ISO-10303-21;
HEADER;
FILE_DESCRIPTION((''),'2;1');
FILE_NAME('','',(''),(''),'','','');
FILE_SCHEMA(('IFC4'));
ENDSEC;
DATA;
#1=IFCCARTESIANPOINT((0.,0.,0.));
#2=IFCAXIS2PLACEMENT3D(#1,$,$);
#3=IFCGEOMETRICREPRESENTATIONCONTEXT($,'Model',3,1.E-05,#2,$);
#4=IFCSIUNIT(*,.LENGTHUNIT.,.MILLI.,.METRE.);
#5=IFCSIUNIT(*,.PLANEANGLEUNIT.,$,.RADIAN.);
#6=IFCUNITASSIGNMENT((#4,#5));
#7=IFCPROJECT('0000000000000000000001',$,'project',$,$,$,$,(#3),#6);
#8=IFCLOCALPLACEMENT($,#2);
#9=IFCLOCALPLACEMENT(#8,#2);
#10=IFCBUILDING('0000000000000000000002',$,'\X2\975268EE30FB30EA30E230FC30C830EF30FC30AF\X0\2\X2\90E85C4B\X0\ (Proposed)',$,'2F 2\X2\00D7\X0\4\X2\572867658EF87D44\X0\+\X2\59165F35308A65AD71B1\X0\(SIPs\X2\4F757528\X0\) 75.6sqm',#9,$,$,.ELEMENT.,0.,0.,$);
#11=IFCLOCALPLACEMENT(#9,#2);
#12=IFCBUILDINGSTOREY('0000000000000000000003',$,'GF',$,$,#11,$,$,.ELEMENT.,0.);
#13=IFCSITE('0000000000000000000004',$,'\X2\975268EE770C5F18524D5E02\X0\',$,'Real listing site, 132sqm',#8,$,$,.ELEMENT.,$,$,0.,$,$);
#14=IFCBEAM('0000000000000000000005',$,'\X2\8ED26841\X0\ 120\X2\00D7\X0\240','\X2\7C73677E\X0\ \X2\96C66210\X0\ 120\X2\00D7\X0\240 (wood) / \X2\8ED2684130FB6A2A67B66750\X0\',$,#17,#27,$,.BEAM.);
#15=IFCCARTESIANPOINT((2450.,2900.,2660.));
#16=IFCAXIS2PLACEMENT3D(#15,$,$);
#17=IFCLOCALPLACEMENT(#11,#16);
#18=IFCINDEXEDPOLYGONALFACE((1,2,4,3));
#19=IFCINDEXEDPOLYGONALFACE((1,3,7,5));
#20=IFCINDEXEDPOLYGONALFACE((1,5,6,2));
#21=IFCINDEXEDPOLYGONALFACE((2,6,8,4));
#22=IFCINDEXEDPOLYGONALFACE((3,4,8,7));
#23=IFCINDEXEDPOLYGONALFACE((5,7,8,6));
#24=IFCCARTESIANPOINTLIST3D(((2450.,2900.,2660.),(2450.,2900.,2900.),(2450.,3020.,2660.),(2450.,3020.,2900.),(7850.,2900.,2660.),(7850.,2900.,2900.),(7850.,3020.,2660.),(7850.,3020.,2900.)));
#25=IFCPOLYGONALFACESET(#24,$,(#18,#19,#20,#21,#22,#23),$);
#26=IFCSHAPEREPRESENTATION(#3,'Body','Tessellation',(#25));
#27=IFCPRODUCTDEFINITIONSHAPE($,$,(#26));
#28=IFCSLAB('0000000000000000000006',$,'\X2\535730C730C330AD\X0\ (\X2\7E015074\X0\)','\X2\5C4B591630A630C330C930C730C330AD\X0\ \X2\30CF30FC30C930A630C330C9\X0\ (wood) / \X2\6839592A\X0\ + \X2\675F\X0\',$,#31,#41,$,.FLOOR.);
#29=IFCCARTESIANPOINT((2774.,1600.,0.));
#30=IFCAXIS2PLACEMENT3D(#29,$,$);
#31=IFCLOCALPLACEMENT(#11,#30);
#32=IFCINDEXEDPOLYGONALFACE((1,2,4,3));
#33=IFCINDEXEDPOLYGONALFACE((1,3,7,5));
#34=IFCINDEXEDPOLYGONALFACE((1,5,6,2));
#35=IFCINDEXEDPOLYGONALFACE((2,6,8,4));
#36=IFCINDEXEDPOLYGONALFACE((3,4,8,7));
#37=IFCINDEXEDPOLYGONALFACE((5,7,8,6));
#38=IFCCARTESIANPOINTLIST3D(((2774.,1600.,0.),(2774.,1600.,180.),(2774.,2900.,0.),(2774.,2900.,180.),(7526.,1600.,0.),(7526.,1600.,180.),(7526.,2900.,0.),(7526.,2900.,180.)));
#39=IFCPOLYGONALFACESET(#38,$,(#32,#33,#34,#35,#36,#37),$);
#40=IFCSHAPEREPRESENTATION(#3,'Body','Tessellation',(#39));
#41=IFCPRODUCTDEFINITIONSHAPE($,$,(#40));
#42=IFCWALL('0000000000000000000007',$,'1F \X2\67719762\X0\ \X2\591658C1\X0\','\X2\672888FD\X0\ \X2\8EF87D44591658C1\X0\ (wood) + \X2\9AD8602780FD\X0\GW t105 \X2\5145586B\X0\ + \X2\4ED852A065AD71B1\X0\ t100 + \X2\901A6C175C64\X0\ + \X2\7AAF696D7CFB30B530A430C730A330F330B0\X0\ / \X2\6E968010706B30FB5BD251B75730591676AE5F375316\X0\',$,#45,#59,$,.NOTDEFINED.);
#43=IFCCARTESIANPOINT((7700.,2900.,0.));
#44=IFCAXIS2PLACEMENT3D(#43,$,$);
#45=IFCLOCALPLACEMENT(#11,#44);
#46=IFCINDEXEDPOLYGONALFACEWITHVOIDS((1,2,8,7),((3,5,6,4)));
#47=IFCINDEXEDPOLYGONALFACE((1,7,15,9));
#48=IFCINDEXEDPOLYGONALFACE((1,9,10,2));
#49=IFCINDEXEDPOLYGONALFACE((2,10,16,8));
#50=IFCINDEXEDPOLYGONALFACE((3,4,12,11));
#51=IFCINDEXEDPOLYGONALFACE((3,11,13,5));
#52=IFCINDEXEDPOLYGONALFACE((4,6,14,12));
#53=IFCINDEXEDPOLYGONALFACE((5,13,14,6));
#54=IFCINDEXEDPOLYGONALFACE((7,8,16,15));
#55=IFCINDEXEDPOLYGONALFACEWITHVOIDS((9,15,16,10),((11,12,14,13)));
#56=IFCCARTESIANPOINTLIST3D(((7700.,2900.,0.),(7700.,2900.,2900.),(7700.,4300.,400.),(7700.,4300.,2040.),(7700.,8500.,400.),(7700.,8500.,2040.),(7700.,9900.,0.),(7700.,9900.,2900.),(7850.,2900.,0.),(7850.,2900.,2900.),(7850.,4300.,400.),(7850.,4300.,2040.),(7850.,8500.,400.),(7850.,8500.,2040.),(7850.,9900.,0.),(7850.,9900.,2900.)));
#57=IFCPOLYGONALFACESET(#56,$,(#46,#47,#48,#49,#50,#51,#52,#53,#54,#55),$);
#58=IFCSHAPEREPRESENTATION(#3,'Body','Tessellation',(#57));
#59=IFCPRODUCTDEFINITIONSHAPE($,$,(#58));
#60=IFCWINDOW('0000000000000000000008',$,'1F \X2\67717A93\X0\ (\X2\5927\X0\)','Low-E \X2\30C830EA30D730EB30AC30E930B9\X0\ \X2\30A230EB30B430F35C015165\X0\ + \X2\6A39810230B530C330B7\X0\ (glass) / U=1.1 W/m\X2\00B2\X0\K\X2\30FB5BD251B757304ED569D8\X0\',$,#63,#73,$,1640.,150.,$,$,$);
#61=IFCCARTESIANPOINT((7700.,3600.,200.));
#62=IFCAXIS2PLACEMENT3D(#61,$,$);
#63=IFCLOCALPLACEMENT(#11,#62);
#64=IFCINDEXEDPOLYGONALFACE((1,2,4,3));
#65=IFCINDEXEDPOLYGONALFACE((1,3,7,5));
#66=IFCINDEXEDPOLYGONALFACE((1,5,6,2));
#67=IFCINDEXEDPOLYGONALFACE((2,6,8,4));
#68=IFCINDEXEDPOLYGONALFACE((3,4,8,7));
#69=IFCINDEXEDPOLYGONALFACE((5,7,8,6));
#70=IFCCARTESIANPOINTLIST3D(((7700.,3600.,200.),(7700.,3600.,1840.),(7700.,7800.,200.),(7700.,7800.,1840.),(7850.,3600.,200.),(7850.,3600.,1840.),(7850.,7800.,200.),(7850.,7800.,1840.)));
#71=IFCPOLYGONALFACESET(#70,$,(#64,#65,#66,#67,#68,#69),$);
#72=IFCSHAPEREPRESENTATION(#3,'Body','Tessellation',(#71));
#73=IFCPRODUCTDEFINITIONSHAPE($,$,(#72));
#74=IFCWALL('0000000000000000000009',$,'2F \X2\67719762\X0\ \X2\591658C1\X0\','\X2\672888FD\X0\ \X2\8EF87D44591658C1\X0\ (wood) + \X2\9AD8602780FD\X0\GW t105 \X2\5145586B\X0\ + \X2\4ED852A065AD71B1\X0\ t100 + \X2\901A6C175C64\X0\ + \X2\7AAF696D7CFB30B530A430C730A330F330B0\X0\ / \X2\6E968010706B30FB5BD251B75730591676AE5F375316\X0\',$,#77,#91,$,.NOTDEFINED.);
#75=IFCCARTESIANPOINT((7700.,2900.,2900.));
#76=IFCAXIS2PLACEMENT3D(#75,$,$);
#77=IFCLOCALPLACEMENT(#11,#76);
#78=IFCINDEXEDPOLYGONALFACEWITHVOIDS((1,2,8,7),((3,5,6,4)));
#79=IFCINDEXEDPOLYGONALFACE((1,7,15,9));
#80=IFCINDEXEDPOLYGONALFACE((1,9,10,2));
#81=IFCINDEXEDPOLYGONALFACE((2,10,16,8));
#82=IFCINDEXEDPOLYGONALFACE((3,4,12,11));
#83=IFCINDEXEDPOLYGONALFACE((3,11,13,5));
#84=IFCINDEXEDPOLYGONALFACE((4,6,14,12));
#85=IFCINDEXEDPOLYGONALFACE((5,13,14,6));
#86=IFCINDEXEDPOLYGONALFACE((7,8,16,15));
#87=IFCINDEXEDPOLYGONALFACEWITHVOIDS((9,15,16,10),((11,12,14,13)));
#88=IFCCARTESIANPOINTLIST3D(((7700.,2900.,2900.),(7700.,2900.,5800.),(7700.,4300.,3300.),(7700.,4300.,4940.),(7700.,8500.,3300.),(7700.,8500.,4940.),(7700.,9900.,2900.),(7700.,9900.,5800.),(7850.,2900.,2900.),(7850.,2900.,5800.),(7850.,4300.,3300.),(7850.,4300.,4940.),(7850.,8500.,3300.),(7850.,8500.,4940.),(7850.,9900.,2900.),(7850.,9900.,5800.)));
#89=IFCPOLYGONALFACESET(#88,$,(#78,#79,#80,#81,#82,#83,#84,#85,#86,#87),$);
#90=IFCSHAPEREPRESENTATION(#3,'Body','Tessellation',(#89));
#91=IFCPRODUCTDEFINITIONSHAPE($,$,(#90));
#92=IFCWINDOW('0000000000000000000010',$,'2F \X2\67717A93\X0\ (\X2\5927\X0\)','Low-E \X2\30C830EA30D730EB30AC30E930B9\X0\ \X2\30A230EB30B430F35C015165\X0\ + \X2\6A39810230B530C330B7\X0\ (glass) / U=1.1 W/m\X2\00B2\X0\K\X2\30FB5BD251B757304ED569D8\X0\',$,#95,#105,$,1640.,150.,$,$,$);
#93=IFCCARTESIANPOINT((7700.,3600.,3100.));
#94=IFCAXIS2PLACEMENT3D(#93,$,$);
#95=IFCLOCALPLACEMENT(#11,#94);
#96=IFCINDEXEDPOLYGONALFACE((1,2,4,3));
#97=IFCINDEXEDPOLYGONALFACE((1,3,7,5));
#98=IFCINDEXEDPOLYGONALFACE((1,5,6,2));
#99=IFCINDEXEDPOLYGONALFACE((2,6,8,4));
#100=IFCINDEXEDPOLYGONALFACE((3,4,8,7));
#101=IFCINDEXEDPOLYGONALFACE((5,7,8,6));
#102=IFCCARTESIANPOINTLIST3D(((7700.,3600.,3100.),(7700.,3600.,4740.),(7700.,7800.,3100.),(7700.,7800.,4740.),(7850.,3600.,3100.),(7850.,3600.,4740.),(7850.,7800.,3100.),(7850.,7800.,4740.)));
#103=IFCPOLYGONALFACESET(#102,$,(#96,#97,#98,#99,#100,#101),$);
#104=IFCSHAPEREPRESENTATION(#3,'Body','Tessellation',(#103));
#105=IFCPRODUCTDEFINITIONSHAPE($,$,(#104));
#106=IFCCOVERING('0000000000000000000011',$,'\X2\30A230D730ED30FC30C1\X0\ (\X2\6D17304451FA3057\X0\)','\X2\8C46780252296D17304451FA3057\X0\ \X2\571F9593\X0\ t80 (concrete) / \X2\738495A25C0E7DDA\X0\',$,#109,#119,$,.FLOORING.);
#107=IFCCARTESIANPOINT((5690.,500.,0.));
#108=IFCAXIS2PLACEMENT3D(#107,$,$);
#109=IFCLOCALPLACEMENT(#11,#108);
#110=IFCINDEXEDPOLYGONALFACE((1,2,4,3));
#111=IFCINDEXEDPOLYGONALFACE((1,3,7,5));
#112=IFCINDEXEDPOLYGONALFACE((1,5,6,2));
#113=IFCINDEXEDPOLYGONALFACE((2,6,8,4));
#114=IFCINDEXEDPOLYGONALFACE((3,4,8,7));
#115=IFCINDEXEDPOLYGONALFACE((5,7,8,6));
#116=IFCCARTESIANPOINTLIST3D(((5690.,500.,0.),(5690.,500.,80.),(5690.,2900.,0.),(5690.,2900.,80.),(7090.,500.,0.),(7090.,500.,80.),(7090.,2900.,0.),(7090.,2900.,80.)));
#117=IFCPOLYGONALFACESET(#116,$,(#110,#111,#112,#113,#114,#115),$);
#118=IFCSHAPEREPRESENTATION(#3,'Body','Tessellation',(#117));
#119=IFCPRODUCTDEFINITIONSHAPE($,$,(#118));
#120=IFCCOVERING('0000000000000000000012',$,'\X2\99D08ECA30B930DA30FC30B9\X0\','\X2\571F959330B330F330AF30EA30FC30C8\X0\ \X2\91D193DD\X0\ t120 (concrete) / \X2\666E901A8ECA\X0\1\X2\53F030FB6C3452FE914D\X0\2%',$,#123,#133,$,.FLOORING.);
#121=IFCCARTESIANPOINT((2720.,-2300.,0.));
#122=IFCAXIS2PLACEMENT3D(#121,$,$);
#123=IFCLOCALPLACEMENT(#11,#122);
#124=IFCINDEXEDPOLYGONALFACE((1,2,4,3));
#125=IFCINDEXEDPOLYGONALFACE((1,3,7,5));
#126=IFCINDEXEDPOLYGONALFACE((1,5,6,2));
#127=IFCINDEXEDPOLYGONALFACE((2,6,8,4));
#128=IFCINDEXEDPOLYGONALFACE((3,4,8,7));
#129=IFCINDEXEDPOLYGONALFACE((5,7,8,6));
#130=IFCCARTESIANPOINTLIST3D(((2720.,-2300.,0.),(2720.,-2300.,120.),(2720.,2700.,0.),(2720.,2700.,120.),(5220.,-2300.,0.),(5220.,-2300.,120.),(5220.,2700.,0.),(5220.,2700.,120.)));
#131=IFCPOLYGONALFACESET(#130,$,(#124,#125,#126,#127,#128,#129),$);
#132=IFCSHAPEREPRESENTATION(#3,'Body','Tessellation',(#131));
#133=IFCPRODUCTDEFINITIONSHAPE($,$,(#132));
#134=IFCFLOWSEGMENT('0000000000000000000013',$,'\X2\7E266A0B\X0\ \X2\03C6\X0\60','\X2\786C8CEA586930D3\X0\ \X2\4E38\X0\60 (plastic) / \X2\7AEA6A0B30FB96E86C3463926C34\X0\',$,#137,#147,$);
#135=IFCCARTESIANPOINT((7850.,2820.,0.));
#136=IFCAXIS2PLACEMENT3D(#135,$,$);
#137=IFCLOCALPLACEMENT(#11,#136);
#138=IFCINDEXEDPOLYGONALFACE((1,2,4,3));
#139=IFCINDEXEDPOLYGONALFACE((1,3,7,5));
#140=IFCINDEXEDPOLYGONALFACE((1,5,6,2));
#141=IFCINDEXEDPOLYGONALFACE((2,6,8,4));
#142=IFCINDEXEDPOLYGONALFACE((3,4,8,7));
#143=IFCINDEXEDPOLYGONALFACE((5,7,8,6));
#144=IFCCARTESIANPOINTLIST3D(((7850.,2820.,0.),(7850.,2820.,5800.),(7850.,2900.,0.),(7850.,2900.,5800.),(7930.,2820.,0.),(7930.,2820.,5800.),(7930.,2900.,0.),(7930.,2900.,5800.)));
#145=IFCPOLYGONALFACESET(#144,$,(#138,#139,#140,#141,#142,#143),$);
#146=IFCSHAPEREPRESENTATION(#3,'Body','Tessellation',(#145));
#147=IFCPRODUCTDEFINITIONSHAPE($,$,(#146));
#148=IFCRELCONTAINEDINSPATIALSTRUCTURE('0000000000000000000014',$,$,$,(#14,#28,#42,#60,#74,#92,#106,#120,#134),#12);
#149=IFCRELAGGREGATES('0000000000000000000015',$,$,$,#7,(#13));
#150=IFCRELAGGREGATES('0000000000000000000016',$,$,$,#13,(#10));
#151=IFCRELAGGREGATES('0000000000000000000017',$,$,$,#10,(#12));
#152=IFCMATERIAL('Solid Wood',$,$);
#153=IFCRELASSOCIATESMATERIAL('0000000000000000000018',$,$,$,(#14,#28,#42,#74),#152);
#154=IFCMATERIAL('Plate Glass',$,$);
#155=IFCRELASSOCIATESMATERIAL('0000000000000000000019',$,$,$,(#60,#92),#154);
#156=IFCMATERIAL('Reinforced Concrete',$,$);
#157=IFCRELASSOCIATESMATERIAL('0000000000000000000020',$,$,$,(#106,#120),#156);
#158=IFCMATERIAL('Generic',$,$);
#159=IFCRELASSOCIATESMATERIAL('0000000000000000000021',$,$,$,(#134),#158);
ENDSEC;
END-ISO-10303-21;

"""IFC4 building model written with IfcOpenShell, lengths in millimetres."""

from ifc_helpers import new_model, si_unit, frame, frame_2d, origin, place, context, project, spatial, rectangle, extrude, material, element, fill, save


model = new_model("IFC4")

# Units and contexts
model_context = context("Model", 3, precision=1e-05, world=origin())
ifc_project = project(units=[si_unit("LENGTHUNIT", "METRE", prefix="MILLI"), si_unit("PLANEANGLEUNIT", "RADIAN")], contexts=[model_context])

# Site, building, storey
site_placement = place(None, origin())
site = spatial("IfcSite", under=ifc_project, at=site_placement, Name="青森県弘前市", ObjectType="Real listing site, 132sqm", CompositionType="ELEMENT", RefElevation=0.0)
building_placement = place(site_placement, origin())
building = spatial("IfcBuilding", under=site, at=building_placement, Name="青森・リモートワーク2部屋 (Proposed)", ObjectType="2F 2×4在来軸組+外張り断熱(SIPs併用) 75.6sqm", CompositionType="ELEMENT", ElevationOfRefHeight=0.0, ElevationOfTerrain=0.0)
storey_placement = place(building_placement, origin())
storey = spatial("IfcBuildingStorey", under=building, at=storey_placement, Name="GF", CompositionType="ELEMENT", Elevation=0.0)

# Shared definitions
ifc_material_1 = material(Name="Solid Wood")

# Beam
beam_1_placement = place(storey_placement, frame((2450.0, 2900.0, 2660.0)))
element("IfcBeam", 1, at=beam_1_placement, inside=storey, material=ifc_material_1, Name="軒桁 120×240", Description="米松 集成 120×240 (wood) / 軒桁・横架材", PredefinedType="BEAM", context=model_context, shape_type="SweptSolid", body=[
    extrude(rectangle(XDim=5400.0, YDim=120.0, at=frame_2d((2700.0, 60.0))), frame((2450.0, 2900.0, 2660.0)), (0.0, 0.0, 1.0), 240.0),
])

# Slab
slab_placement = place(storey_placement, frame((2774.0, 1600.0, 0.0)))
element("IfcSlab", 2, at=slab_placement, inside=storey, material=ifc_material_1, Name="南デッキ (縁側)", Description="屋外ウッドデッキ ハードウッド (wood) / 根太 + 束", PredefinedType="FLOOR", context=model_context, shape_type="SweptSolid", body=[
    extrude(rectangle(XDim=4752.0, YDim=1300.0, at=frame_2d((2376.0, 650.0))), frame((2774.0, 1600.0, 0.0)), (0.0, 0.0, 1.0), 180.0),
])

# Walls, openings, windows
wall_1_placement = place(storey_placement, frame((7700.0, 2900.0, 0.0)))
wall_1 = element("IfcWall", 3, at=wall_1_placement, inside=storey, material=ifc_material_1, Name="1F 東面 外壁", Description="木製 軸組外壁 (wood) + 高性能GW t105 充填 + 付加断熱 t100 + 通気層 + 窯業系サイディング / 準耐火・寒冷地外皮強化", PredefinedType="NOTDEFINED", context=model_context, shape_type="SweptSolid", body=[
    extrude(rectangle(XDim=150.0, YDim=7000.0, at=frame_2d((75.0, 3500.0))), frame((7700.0, 2900.0, 0.0)), (0.0, 0.0, 1.0), 2900.0),
])
opening_1_placement = place(storey_placement, frame((7700.0, 3600.0, 200.0)))
opening_1 = element("IfcOpeningElement", 4, at=opening_1_placement, cuts=wall_1, PredefinedType="NOTDEFINED", context=model_context, shape_type="SweptSolid", body=[
    extrude(rectangle(XDim=150.0, YDim=4200.0, at=frame_2d((75.0, 2100.0))), frame((7700.0, 3600.0, 200.0)), (0.0, 0.0, 1.0), 1640.0),
])
ifc_material_2 = material(Name="Plate Glass")
window_1_placement = place(storey_placement, frame((7700.0, 3600.0, 200.0)))
window_1 = element("IfcWindow", 5, at=window_1_placement, inside=storey, material=ifc_material_2, Name="1F 東窓 (大)", Description="Low-E トリプルガラス アルゴン封入 + 樹脂サッシ (glass) / U=1.1 W/m²K・寒冷地仕様", OverallHeight=1640.0, OverallWidth=150.0, context=model_context, shape_type="SweptSolid", body=[
    extrude(rectangle(XDim=150.0, YDim=4200.0, at=frame_2d((75.0, 2100.0))), frame((7700.0, 3600.0, 200.0)), (0.0, 0.0, 1.0), 1640.0),
])
fill(opening_1, window_1)
wall_2_placement = place(storey_placement, frame((7700.0, 2900.0, 2900.0)))
wall_2 = element("IfcWall", 6, at=wall_2_placement, inside=storey, material=ifc_material_1, Name="2F 東面 外壁", Description="木製 軸組外壁 (wood) + 高性能GW t105 充填 + 付加断熱 t100 + 通気層 + 窯業系サイディング / 準耐火・寒冷地外皮強化", PredefinedType="NOTDEFINED", context=model_context, shape_type="SweptSolid", body=[
    extrude(rectangle(XDim=150.0, YDim=7000.0, at=frame_2d((75.0, 3500.0))), frame((7700.0, 2900.0, 2900.0)), (0.0, 0.0, 1.0), 2900.0),
])
opening_2_placement = place(storey_placement, frame((7700.0, 3600.0, 3100.0)))
opening_2 = element("IfcOpeningElement", 7, at=opening_2_placement, cuts=wall_2, PredefinedType="NOTDEFINED", context=model_context, shape_type="SweptSolid", body=[
    extrude(rectangle(XDim=150.0, YDim=4200.0, at=frame_2d((75.0, 2100.0))), frame((7700.0, 3600.0, 3100.0)), (0.0, 0.0, 1.0), 1640.0),
])
window_2_placement = place(storey_placement, frame((7700.0, 3600.0, 3100.0)))
window_2 = element("IfcWindow", 8, at=window_2_placement, inside=storey, material=ifc_material_2, Name="2F 東窓 (大)", Description="Low-E トリプルガラス アルゴン封入 + 樹脂サッシ (glass) / U=1.1 W/m²K・寒冷地仕様", OverallHeight=1640.0, OverallWidth=150.0, context=model_context, shape_type="SweptSolid", body=[
    extrude(rectangle(XDim=150.0, YDim=4200.0, at=frame_2d((75.0, 2100.0))), frame((7700.0, 3600.0, 3100.0)), (0.0, 0.0, 1.0), 1640.0),
])
fill(opening_2, window_2)

# Coverings
ifc_material_3 = material(Name="Reinforced Concrete")
covering_1_placement = place(storey_placement, frame((5690.0, 500.0, 0.0)))
element("IfcCovering", 9, at=covering_1_placement, inside=storey, material=ifc_material_3, Name="アプローチ (洗い出し)", Description="豆砂利洗い出し 土間 t80 (concrete) / 玄関導線", PredefinedType="FLOORING", context=model_context, shape_type="SweptSolid", body=[
    extrude(rectangle(XDim=1400.0, YDim=2400.0, at=frame_2d((700.0, 1200.0))), frame((5690.0, 500.0, 0.0)), (0.0, 0.0, 1.0), 80.0),
])
covering_2_placement = place(storey_placement, frame((2720.0, -2300.0, 0.0)))
element("IfcCovering", 10, at=covering_2_placement, inside=storey, material=ifc_material_3, Name="駐車スペース", Description="土間コンクリート 金鏝 t120 (concrete) / 普通車1台・水勾配2%", PredefinedType="FLOORING", context=model_context, shape_type="SweptSolid", body=[
    extrude(rectangle(XDim=2500.0, YDim=5000.0, at=frame_2d((1250.0, 2500.0))), frame((2720.0, -2300.0, 0.0)), (0.0, 0.0, 1.0), 120.0),
])

# Flow segment
ifc_material_4 = material(Name="Generic")
flow_segment_placement = place(storey_placement, frame((7850.0, 2820.0, 0.0)))
element("IfcFlowSegment", 11, at=flow_segment_placement, inside=storey, material=ifc_material_4, Name="縦樋 φ60", Description="硬質塩ビ 丸60 (plastic) / 竪樋・雨水排水", context=model_context, shape_type="SweptSolid", body=[
    extrude(rectangle(XDim=80.0, YDim=80.0, at=frame_2d((40.0, 40.0))), frame((7850.0, 2820.0, 0.0)), (0.0, 0.0, 1.0), 5800.0),
])

save(model, "model.ifc")
